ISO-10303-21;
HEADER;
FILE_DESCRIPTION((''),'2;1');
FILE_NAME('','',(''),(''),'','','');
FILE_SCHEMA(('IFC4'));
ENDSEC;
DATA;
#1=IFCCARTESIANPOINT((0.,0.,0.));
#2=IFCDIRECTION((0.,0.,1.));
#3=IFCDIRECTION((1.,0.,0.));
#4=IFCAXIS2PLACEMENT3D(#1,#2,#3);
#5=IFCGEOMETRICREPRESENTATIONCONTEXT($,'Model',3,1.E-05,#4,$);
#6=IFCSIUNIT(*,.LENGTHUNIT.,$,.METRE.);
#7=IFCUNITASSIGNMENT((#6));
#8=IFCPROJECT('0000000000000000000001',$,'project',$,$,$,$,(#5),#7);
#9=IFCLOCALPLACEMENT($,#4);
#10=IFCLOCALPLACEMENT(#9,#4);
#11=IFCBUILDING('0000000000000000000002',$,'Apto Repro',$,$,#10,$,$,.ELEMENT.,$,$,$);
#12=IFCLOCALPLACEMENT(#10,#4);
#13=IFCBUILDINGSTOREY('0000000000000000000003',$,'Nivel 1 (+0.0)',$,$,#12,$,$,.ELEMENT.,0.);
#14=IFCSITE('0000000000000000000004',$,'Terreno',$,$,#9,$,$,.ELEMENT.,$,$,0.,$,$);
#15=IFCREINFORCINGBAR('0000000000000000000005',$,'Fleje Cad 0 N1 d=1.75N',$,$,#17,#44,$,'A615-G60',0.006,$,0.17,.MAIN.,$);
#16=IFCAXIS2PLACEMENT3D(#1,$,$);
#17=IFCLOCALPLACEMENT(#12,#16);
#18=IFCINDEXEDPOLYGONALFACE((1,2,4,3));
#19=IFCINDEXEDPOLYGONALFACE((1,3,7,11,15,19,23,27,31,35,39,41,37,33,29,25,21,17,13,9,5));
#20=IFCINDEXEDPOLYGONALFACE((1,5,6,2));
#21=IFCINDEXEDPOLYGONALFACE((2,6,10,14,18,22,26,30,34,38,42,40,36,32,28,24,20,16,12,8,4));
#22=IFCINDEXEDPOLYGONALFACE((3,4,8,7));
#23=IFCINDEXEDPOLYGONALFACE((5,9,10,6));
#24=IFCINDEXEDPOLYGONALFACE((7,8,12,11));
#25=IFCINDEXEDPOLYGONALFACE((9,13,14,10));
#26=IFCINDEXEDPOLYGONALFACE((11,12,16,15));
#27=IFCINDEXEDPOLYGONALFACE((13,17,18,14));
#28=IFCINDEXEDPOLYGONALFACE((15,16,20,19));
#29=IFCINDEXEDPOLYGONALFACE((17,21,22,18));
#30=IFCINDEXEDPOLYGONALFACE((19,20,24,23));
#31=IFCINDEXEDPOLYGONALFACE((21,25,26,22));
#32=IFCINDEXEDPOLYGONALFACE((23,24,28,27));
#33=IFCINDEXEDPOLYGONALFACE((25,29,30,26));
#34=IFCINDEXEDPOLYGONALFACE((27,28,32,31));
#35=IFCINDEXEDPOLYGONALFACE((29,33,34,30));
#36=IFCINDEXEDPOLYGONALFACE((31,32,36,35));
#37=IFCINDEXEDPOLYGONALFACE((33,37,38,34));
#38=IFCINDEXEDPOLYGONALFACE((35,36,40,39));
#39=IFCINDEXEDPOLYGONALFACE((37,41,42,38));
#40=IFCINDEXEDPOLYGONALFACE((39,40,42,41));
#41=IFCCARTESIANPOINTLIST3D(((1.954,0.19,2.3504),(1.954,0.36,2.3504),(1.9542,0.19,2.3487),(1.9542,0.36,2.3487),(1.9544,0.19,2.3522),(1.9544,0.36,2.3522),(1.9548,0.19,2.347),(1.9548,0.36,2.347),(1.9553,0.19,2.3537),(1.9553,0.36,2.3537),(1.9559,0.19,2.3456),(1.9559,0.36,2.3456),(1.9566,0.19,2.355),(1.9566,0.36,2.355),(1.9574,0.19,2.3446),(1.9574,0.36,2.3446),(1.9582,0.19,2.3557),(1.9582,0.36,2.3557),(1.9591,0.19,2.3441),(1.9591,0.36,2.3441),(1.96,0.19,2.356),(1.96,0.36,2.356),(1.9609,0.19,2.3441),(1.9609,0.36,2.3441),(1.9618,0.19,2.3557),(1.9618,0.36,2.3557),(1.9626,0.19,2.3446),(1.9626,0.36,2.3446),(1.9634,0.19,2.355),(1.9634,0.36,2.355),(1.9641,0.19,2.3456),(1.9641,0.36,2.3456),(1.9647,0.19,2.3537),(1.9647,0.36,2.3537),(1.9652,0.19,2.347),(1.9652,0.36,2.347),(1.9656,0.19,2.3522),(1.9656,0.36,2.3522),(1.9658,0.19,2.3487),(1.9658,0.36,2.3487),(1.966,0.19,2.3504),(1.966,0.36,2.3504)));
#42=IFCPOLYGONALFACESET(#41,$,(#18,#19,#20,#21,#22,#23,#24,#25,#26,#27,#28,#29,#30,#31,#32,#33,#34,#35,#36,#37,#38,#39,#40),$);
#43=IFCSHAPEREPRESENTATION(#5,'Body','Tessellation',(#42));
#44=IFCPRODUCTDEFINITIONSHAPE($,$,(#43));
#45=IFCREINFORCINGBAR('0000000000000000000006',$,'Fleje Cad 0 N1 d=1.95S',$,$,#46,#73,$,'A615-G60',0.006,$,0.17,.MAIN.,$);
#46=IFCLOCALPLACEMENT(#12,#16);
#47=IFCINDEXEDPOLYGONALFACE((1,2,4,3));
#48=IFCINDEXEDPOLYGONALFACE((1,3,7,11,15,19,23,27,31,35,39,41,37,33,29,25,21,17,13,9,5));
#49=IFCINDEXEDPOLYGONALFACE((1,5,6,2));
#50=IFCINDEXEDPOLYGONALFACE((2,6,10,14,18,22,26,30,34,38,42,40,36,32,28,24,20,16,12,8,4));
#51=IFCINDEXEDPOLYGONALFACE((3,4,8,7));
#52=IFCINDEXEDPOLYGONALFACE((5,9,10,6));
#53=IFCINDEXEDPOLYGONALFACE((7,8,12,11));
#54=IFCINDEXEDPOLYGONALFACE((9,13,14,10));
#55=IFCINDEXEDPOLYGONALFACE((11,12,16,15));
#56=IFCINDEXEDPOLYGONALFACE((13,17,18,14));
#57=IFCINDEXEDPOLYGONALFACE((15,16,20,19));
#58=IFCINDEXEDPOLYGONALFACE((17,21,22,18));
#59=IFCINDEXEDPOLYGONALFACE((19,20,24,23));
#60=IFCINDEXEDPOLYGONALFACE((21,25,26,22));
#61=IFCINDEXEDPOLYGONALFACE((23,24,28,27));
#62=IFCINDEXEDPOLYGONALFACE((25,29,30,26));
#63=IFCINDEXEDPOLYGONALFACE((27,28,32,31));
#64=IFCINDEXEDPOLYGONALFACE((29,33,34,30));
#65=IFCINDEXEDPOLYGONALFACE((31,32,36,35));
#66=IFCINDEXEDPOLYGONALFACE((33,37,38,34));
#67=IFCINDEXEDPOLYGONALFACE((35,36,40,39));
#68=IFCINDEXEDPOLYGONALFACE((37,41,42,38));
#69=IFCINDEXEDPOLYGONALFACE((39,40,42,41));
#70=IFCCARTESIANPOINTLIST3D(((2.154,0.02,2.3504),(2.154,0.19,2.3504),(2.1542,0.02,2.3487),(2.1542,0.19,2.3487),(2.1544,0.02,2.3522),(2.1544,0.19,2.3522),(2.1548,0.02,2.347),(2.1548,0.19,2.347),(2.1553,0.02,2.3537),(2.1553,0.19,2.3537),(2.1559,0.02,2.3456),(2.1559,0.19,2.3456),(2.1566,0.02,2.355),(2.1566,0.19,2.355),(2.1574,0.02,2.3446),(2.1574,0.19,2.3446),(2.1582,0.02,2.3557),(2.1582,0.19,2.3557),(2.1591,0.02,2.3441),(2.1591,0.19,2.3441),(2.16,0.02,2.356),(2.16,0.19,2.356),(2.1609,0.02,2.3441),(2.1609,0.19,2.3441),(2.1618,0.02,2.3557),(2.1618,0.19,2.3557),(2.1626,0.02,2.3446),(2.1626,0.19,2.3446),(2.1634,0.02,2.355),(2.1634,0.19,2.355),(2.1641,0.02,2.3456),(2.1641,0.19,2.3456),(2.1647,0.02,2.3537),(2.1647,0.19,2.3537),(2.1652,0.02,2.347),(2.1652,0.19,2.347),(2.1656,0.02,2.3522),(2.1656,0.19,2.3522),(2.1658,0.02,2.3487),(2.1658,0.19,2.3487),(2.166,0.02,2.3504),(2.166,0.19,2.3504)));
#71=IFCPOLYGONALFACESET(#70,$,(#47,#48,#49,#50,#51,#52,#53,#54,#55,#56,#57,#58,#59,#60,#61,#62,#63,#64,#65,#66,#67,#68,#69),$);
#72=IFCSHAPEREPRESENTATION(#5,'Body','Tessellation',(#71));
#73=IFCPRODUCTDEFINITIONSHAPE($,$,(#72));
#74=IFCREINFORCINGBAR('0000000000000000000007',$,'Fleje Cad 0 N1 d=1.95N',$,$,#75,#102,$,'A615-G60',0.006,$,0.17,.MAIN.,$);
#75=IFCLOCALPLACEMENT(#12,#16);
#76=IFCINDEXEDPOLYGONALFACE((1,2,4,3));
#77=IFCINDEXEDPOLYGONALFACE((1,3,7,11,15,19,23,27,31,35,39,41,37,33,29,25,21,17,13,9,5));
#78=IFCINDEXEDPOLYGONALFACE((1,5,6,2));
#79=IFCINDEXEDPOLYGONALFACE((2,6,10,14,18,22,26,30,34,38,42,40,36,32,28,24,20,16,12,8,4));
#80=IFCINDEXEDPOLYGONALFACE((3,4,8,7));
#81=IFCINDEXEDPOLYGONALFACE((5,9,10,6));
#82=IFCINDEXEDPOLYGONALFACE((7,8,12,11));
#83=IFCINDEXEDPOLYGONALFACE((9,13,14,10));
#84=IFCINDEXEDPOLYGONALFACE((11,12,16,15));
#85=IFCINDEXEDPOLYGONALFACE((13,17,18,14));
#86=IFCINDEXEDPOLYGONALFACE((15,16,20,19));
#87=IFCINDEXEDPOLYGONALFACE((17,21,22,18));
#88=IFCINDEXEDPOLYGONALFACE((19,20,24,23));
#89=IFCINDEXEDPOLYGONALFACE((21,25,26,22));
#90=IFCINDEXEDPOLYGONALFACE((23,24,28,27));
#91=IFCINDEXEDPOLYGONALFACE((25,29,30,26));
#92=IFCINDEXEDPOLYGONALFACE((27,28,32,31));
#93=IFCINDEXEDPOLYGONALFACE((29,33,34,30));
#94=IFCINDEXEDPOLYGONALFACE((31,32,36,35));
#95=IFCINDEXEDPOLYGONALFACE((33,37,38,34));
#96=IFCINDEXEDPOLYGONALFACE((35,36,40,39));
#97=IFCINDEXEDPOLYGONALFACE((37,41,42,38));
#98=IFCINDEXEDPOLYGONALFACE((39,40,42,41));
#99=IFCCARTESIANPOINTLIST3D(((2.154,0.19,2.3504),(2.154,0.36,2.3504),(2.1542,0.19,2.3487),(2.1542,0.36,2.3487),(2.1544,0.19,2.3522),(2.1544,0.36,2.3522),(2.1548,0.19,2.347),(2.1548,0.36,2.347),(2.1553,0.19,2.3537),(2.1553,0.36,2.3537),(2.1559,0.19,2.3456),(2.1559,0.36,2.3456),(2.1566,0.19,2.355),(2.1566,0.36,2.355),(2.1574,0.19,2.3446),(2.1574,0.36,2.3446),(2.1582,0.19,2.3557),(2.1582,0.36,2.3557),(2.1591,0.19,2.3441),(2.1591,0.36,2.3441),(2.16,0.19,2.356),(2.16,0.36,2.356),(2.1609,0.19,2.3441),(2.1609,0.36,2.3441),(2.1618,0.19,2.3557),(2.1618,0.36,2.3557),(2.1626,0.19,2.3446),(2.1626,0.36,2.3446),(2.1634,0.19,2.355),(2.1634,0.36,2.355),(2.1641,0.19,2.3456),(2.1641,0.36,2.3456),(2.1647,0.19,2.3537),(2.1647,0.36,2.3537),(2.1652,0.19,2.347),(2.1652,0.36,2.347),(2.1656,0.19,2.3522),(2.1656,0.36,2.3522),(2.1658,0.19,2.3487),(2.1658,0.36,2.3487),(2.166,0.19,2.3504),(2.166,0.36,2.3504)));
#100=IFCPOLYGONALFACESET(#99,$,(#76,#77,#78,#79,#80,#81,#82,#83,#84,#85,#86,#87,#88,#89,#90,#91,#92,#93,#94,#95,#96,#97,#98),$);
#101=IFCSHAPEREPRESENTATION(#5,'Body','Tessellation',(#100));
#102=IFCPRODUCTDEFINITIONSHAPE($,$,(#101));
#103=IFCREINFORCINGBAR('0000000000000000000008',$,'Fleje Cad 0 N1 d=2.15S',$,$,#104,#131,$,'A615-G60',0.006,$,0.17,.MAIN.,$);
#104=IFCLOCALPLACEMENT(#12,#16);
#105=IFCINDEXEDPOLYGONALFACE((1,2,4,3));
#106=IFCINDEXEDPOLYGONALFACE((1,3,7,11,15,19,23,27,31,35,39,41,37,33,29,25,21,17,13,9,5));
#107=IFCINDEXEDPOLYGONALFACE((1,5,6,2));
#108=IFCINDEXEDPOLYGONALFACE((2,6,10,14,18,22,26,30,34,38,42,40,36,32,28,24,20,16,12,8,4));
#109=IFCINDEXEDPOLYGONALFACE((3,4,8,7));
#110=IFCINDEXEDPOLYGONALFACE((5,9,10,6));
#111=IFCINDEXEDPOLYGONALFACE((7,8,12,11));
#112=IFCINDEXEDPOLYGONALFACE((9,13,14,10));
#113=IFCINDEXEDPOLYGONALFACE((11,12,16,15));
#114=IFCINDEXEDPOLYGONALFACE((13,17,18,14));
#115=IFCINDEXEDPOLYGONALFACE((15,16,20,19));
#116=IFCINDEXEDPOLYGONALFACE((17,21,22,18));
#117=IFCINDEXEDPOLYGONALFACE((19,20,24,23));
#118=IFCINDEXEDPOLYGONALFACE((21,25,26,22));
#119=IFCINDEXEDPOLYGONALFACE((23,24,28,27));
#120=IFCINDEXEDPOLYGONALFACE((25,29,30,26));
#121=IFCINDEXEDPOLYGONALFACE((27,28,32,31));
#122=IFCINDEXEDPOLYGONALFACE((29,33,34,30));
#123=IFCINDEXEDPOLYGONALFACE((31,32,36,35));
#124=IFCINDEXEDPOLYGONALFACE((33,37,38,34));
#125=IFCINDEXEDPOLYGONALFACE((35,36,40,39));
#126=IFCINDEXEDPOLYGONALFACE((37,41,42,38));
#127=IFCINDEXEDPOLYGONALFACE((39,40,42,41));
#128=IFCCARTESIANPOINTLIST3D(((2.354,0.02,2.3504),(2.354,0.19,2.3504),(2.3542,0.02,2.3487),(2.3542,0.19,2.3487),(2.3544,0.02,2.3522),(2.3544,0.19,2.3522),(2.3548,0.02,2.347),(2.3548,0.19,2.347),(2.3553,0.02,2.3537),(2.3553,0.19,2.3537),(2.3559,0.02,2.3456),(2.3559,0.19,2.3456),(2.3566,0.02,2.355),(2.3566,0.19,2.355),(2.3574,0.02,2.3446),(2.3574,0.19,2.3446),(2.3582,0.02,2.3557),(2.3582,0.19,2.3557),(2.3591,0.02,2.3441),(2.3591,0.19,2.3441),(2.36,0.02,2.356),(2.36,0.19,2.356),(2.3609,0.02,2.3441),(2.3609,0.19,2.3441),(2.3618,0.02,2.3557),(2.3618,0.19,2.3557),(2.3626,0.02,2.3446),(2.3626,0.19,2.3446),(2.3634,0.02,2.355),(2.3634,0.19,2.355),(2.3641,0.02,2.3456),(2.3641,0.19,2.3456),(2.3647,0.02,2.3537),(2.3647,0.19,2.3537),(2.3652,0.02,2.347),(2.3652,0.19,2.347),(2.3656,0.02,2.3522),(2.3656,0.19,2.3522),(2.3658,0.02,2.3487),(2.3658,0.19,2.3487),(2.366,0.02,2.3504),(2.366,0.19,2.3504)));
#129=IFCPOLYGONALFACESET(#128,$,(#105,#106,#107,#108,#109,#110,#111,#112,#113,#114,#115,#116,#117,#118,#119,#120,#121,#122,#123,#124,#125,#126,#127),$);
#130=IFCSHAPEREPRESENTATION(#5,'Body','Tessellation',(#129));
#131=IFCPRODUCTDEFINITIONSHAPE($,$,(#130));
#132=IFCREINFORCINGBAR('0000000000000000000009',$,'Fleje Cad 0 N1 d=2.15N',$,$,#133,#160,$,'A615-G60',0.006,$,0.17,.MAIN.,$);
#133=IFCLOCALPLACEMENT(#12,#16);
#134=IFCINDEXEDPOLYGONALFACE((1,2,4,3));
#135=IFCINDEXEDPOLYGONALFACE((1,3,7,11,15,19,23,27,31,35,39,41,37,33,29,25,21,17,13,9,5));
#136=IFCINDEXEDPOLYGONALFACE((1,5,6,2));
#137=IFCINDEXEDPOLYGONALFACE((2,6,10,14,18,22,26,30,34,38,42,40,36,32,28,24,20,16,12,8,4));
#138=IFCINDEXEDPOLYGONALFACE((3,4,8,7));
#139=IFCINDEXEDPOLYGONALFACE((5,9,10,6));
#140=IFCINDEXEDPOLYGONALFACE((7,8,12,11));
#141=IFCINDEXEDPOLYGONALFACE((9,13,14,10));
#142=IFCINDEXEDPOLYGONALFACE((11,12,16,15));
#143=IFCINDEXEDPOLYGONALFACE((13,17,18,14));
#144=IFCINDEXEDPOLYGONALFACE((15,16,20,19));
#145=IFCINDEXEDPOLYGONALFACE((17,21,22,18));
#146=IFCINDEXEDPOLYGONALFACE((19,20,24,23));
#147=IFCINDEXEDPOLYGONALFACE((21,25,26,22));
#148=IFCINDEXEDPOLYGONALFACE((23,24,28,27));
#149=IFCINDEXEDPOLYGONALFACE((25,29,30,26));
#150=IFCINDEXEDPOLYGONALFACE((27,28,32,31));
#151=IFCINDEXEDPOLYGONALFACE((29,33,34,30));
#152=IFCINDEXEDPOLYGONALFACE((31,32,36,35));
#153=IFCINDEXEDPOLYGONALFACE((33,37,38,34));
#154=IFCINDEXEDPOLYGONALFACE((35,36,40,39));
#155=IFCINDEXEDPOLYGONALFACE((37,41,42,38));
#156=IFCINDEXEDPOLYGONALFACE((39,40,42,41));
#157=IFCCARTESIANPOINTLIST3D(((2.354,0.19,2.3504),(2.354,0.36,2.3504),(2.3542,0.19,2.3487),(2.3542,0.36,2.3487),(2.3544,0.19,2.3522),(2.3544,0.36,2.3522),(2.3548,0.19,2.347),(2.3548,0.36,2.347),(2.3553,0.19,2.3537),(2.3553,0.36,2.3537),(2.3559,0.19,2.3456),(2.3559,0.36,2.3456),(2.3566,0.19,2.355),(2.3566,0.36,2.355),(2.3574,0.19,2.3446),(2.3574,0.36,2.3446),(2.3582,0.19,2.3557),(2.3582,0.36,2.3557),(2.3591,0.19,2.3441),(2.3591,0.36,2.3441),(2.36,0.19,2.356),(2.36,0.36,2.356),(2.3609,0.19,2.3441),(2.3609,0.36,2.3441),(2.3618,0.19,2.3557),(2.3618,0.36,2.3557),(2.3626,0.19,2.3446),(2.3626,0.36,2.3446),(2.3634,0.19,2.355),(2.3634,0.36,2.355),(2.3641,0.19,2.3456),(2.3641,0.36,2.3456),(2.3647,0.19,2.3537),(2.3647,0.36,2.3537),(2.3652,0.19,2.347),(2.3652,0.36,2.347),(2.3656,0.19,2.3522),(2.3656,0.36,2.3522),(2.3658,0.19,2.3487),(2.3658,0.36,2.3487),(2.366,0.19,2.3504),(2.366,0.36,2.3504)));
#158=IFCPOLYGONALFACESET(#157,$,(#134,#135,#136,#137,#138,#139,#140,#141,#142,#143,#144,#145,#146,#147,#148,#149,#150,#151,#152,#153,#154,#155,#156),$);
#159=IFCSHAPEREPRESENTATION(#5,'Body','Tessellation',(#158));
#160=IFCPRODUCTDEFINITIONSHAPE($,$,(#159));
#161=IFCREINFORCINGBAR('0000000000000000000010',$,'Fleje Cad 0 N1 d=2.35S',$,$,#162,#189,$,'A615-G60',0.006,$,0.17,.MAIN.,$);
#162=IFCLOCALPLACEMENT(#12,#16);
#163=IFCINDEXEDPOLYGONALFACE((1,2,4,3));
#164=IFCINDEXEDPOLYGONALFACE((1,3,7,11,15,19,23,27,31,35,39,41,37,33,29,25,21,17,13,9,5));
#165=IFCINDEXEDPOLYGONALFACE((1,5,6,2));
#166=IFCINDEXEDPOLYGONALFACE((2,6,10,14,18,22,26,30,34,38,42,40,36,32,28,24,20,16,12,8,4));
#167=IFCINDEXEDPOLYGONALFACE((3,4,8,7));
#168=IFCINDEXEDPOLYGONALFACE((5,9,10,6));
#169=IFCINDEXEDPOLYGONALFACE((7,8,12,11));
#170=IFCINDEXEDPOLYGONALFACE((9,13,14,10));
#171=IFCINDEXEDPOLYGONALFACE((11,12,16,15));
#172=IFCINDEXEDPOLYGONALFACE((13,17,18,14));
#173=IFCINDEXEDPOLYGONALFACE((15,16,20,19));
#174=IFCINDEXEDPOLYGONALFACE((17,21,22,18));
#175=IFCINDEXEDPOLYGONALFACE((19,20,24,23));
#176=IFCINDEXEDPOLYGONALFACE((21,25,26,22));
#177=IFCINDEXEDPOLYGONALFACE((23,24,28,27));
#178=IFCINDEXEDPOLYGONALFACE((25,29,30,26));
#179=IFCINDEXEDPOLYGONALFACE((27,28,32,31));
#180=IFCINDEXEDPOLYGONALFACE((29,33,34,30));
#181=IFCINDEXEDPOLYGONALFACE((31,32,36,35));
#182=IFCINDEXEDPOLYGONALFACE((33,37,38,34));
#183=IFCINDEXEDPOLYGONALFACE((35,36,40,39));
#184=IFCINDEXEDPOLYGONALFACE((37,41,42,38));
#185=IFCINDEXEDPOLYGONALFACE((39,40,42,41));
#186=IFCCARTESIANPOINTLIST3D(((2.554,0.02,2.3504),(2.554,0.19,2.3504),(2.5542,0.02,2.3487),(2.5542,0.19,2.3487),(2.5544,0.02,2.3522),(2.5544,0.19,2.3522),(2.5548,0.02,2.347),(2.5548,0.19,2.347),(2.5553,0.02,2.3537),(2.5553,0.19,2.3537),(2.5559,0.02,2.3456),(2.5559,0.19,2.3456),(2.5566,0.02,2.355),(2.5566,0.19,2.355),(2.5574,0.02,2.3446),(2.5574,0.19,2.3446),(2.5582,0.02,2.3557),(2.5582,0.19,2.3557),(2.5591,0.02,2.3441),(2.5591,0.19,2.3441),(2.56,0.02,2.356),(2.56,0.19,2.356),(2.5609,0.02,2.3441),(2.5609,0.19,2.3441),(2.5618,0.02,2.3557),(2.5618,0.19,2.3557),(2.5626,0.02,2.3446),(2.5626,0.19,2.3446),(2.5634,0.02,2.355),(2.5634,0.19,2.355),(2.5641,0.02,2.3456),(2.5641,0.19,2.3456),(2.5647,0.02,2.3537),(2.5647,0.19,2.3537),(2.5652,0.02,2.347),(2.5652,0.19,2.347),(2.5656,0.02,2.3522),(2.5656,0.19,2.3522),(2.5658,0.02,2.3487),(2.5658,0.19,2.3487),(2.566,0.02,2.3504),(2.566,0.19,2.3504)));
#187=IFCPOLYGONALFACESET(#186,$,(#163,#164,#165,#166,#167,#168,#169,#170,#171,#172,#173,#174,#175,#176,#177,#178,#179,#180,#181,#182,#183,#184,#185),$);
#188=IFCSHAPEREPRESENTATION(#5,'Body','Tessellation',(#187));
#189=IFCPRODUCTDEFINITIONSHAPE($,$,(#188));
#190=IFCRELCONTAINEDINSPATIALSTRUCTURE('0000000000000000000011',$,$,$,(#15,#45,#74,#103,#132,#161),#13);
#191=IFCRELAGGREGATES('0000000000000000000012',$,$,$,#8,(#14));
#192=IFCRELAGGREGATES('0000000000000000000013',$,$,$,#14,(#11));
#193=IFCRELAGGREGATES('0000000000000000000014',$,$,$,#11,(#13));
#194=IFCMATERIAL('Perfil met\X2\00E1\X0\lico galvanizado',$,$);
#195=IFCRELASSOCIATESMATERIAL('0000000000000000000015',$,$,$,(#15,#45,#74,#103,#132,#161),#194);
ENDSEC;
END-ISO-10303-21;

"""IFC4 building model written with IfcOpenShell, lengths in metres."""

from ifc_helpers import new_model, si_unit, frame, origin_with_axes, origin_2d_with_axis, place, context, project, spatial, circle, extrude, material, element, save


model = new_model("IFC4")

# Units and contexts
model_context = context("Model", 3, precision=1e-05, world=origin_with_axes())
ifc_project = project(units=[si_unit("LENGTHUNIT", "METRE")], contexts=[model_context])

# Site, building, storey
site_placement = place(None, origin_with_axes())
site = spatial("IfcSite", under=ifc_project, at=site_placement, Name="Terreno", CompositionType="ELEMENT", RefElevation=0.0)
building_placement = place(site_placement, origin_with_axes())
building = spatial("IfcBuilding", under=site, at=building_placement, Name="Apto Repro", CompositionType="ELEMENT")
storey_placement = place(building_placement, origin_with_axes())
storey = spatial("IfcBuildingStorey", under=building, at=storey_placement, Name="Nivel 1 (+0.0)", CompositionType="ELEMENT", Elevation=0.0)

# Reinforcing bars
ifc_material = material(Name="Perfil metálico galvanizado")
reinforcing_bar_1_placement = place(storey_placement, origin_with_axes())
element("IfcReinforcingBar", 1, at=reinforcing_bar_1_placement, inside=storey, material=ifc_material, Name="Fleje Cad 0 N1 d=1.75N", SteelGrade="A615-G60", BarLength=0.17, NominalDiameter=0.006, PredefinedType="MAIN", context=model_context, shape_type="SweptSolid", body=[
    extrude(circle(Radius=0.006, at=origin_2d_with_axis()), frame((1.96, 0.19, 2.35), z_axis=(0.0, 1.0, 0.0), x_axis=(0.0, 0.0, 1.0)), (0.0, 0.0, 1.0), 0.17),
])
reinforcing_bar_2_placement = place(storey_placement, origin_with_axes())
element("IfcReinforcingBar", 2, at=reinforcing_bar_2_placement, inside=storey, material=ifc_material, Name="Fleje Cad 0 N1 d=1.95S", SteelGrade="A615-G60", BarLength=0.17, NominalDiameter=0.006, PredefinedType="MAIN", context=model_context, shape_type="SweptSolid", body=[
    extrude(circle(Radius=0.006, at=origin_2d_with_axis()), frame((2.16, 0.02, 2.35), z_axis=(0.0, 1.0, 0.0), x_axis=(0.0, 0.0, 1.0)), (0.0, 0.0, 1.0), 0.17),
])
reinforcing_bar_3_placement = place(storey_placement, origin_with_axes())
element("IfcReinforcingBar", 3, at=reinforcing_bar_3_placement, inside=storey, material=ifc_material, Name="Fleje Cad 0 N1 d=1.95N", SteelGrade="A615-G60", BarLength=0.17, NominalDiameter=0.006, PredefinedType="MAIN", context=model_context, shape_type="SweptSolid", body=[
    extrude(circle(Radius=0.006, at=origin_2d_with_axis()), frame((2.16, 0.19, 2.35), z_axis=(0.0, 1.0, 0.0), x_axis=(0.0, 0.0, 1.0)), (0.0, 0.0, 1.0), 0.17),
])
reinforcing_bar_4_placement = place(storey_placement, origin_with_axes())
element("IfcReinforcingBar", 4, at=reinforcing_bar_4_placement, inside=storey, material=ifc_material, Name="Fleje Cad 0 N1 d=2.15S", SteelGrade="A615-G60", BarLength=0.17, NominalDiameter=0.006, PredefinedType="MAIN", context=model_context, shape_type="SweptSolid", body=[
    extrude(circle(Radius=0.006, at=origin_2d_with_axis()), frame((2.36, 0.02, 2.35), z_axis=(0.0, 1.0, 0.0), x_axis=(0.0, 0.0, 1.0)), (0.0, 0.0, 1.0), 0.17),
])
reinforcing_bar_5_placement = place(storey_placement, origin_with_axes())
element("IfcReinforcingBar", 5, at=reinforcing_bar_5_placement, inside=storey, material=ifc_material, Name="Fleje Cad 0 N1 d=2.15N", SteelGrade="A615-G60", BarLength=0.17, NominalDiameter=0.006, PredefinedType="MAIN", context=model_context, shape_type="SweptSolid", body=[
    extrude(circle(Radius=0.006, at=origin_2d_with_axis()), frame((2.36, 0.19, 2.35), z_axis=(0.0, 1.0, 0.0), x_axis=(0.0, 0.0, 1.0)), (0.0, 0.0, 1.0), 0.17),
])
reinforcing_bar_6_placement = place(storey_placement, origin_with_axes())
element("IfcReinforcingBar", 6, at=reinforcing_bar_6_placement, inside=storey, material=ifc_material, Name="Fleje Cad 0 N1 d=2.35S", SteelGrade="A615-G60", BarLength=0.17, NominalDiameter=0.006, PredefinedType="MAIN", context=model_context, shape_type="SweptSolid", body=[
    extrude(circle(Radius=0.006, at=origin_2d_with_axis()), frame((2.56, 0.02, 2.35), z_axis=(0.0, 1.0, 0.0), x_axis=(0.0, 0.0, 1.0)), (0.0, 0.0, 1.0), 0.17),
])

save(model, "model.ifc")
